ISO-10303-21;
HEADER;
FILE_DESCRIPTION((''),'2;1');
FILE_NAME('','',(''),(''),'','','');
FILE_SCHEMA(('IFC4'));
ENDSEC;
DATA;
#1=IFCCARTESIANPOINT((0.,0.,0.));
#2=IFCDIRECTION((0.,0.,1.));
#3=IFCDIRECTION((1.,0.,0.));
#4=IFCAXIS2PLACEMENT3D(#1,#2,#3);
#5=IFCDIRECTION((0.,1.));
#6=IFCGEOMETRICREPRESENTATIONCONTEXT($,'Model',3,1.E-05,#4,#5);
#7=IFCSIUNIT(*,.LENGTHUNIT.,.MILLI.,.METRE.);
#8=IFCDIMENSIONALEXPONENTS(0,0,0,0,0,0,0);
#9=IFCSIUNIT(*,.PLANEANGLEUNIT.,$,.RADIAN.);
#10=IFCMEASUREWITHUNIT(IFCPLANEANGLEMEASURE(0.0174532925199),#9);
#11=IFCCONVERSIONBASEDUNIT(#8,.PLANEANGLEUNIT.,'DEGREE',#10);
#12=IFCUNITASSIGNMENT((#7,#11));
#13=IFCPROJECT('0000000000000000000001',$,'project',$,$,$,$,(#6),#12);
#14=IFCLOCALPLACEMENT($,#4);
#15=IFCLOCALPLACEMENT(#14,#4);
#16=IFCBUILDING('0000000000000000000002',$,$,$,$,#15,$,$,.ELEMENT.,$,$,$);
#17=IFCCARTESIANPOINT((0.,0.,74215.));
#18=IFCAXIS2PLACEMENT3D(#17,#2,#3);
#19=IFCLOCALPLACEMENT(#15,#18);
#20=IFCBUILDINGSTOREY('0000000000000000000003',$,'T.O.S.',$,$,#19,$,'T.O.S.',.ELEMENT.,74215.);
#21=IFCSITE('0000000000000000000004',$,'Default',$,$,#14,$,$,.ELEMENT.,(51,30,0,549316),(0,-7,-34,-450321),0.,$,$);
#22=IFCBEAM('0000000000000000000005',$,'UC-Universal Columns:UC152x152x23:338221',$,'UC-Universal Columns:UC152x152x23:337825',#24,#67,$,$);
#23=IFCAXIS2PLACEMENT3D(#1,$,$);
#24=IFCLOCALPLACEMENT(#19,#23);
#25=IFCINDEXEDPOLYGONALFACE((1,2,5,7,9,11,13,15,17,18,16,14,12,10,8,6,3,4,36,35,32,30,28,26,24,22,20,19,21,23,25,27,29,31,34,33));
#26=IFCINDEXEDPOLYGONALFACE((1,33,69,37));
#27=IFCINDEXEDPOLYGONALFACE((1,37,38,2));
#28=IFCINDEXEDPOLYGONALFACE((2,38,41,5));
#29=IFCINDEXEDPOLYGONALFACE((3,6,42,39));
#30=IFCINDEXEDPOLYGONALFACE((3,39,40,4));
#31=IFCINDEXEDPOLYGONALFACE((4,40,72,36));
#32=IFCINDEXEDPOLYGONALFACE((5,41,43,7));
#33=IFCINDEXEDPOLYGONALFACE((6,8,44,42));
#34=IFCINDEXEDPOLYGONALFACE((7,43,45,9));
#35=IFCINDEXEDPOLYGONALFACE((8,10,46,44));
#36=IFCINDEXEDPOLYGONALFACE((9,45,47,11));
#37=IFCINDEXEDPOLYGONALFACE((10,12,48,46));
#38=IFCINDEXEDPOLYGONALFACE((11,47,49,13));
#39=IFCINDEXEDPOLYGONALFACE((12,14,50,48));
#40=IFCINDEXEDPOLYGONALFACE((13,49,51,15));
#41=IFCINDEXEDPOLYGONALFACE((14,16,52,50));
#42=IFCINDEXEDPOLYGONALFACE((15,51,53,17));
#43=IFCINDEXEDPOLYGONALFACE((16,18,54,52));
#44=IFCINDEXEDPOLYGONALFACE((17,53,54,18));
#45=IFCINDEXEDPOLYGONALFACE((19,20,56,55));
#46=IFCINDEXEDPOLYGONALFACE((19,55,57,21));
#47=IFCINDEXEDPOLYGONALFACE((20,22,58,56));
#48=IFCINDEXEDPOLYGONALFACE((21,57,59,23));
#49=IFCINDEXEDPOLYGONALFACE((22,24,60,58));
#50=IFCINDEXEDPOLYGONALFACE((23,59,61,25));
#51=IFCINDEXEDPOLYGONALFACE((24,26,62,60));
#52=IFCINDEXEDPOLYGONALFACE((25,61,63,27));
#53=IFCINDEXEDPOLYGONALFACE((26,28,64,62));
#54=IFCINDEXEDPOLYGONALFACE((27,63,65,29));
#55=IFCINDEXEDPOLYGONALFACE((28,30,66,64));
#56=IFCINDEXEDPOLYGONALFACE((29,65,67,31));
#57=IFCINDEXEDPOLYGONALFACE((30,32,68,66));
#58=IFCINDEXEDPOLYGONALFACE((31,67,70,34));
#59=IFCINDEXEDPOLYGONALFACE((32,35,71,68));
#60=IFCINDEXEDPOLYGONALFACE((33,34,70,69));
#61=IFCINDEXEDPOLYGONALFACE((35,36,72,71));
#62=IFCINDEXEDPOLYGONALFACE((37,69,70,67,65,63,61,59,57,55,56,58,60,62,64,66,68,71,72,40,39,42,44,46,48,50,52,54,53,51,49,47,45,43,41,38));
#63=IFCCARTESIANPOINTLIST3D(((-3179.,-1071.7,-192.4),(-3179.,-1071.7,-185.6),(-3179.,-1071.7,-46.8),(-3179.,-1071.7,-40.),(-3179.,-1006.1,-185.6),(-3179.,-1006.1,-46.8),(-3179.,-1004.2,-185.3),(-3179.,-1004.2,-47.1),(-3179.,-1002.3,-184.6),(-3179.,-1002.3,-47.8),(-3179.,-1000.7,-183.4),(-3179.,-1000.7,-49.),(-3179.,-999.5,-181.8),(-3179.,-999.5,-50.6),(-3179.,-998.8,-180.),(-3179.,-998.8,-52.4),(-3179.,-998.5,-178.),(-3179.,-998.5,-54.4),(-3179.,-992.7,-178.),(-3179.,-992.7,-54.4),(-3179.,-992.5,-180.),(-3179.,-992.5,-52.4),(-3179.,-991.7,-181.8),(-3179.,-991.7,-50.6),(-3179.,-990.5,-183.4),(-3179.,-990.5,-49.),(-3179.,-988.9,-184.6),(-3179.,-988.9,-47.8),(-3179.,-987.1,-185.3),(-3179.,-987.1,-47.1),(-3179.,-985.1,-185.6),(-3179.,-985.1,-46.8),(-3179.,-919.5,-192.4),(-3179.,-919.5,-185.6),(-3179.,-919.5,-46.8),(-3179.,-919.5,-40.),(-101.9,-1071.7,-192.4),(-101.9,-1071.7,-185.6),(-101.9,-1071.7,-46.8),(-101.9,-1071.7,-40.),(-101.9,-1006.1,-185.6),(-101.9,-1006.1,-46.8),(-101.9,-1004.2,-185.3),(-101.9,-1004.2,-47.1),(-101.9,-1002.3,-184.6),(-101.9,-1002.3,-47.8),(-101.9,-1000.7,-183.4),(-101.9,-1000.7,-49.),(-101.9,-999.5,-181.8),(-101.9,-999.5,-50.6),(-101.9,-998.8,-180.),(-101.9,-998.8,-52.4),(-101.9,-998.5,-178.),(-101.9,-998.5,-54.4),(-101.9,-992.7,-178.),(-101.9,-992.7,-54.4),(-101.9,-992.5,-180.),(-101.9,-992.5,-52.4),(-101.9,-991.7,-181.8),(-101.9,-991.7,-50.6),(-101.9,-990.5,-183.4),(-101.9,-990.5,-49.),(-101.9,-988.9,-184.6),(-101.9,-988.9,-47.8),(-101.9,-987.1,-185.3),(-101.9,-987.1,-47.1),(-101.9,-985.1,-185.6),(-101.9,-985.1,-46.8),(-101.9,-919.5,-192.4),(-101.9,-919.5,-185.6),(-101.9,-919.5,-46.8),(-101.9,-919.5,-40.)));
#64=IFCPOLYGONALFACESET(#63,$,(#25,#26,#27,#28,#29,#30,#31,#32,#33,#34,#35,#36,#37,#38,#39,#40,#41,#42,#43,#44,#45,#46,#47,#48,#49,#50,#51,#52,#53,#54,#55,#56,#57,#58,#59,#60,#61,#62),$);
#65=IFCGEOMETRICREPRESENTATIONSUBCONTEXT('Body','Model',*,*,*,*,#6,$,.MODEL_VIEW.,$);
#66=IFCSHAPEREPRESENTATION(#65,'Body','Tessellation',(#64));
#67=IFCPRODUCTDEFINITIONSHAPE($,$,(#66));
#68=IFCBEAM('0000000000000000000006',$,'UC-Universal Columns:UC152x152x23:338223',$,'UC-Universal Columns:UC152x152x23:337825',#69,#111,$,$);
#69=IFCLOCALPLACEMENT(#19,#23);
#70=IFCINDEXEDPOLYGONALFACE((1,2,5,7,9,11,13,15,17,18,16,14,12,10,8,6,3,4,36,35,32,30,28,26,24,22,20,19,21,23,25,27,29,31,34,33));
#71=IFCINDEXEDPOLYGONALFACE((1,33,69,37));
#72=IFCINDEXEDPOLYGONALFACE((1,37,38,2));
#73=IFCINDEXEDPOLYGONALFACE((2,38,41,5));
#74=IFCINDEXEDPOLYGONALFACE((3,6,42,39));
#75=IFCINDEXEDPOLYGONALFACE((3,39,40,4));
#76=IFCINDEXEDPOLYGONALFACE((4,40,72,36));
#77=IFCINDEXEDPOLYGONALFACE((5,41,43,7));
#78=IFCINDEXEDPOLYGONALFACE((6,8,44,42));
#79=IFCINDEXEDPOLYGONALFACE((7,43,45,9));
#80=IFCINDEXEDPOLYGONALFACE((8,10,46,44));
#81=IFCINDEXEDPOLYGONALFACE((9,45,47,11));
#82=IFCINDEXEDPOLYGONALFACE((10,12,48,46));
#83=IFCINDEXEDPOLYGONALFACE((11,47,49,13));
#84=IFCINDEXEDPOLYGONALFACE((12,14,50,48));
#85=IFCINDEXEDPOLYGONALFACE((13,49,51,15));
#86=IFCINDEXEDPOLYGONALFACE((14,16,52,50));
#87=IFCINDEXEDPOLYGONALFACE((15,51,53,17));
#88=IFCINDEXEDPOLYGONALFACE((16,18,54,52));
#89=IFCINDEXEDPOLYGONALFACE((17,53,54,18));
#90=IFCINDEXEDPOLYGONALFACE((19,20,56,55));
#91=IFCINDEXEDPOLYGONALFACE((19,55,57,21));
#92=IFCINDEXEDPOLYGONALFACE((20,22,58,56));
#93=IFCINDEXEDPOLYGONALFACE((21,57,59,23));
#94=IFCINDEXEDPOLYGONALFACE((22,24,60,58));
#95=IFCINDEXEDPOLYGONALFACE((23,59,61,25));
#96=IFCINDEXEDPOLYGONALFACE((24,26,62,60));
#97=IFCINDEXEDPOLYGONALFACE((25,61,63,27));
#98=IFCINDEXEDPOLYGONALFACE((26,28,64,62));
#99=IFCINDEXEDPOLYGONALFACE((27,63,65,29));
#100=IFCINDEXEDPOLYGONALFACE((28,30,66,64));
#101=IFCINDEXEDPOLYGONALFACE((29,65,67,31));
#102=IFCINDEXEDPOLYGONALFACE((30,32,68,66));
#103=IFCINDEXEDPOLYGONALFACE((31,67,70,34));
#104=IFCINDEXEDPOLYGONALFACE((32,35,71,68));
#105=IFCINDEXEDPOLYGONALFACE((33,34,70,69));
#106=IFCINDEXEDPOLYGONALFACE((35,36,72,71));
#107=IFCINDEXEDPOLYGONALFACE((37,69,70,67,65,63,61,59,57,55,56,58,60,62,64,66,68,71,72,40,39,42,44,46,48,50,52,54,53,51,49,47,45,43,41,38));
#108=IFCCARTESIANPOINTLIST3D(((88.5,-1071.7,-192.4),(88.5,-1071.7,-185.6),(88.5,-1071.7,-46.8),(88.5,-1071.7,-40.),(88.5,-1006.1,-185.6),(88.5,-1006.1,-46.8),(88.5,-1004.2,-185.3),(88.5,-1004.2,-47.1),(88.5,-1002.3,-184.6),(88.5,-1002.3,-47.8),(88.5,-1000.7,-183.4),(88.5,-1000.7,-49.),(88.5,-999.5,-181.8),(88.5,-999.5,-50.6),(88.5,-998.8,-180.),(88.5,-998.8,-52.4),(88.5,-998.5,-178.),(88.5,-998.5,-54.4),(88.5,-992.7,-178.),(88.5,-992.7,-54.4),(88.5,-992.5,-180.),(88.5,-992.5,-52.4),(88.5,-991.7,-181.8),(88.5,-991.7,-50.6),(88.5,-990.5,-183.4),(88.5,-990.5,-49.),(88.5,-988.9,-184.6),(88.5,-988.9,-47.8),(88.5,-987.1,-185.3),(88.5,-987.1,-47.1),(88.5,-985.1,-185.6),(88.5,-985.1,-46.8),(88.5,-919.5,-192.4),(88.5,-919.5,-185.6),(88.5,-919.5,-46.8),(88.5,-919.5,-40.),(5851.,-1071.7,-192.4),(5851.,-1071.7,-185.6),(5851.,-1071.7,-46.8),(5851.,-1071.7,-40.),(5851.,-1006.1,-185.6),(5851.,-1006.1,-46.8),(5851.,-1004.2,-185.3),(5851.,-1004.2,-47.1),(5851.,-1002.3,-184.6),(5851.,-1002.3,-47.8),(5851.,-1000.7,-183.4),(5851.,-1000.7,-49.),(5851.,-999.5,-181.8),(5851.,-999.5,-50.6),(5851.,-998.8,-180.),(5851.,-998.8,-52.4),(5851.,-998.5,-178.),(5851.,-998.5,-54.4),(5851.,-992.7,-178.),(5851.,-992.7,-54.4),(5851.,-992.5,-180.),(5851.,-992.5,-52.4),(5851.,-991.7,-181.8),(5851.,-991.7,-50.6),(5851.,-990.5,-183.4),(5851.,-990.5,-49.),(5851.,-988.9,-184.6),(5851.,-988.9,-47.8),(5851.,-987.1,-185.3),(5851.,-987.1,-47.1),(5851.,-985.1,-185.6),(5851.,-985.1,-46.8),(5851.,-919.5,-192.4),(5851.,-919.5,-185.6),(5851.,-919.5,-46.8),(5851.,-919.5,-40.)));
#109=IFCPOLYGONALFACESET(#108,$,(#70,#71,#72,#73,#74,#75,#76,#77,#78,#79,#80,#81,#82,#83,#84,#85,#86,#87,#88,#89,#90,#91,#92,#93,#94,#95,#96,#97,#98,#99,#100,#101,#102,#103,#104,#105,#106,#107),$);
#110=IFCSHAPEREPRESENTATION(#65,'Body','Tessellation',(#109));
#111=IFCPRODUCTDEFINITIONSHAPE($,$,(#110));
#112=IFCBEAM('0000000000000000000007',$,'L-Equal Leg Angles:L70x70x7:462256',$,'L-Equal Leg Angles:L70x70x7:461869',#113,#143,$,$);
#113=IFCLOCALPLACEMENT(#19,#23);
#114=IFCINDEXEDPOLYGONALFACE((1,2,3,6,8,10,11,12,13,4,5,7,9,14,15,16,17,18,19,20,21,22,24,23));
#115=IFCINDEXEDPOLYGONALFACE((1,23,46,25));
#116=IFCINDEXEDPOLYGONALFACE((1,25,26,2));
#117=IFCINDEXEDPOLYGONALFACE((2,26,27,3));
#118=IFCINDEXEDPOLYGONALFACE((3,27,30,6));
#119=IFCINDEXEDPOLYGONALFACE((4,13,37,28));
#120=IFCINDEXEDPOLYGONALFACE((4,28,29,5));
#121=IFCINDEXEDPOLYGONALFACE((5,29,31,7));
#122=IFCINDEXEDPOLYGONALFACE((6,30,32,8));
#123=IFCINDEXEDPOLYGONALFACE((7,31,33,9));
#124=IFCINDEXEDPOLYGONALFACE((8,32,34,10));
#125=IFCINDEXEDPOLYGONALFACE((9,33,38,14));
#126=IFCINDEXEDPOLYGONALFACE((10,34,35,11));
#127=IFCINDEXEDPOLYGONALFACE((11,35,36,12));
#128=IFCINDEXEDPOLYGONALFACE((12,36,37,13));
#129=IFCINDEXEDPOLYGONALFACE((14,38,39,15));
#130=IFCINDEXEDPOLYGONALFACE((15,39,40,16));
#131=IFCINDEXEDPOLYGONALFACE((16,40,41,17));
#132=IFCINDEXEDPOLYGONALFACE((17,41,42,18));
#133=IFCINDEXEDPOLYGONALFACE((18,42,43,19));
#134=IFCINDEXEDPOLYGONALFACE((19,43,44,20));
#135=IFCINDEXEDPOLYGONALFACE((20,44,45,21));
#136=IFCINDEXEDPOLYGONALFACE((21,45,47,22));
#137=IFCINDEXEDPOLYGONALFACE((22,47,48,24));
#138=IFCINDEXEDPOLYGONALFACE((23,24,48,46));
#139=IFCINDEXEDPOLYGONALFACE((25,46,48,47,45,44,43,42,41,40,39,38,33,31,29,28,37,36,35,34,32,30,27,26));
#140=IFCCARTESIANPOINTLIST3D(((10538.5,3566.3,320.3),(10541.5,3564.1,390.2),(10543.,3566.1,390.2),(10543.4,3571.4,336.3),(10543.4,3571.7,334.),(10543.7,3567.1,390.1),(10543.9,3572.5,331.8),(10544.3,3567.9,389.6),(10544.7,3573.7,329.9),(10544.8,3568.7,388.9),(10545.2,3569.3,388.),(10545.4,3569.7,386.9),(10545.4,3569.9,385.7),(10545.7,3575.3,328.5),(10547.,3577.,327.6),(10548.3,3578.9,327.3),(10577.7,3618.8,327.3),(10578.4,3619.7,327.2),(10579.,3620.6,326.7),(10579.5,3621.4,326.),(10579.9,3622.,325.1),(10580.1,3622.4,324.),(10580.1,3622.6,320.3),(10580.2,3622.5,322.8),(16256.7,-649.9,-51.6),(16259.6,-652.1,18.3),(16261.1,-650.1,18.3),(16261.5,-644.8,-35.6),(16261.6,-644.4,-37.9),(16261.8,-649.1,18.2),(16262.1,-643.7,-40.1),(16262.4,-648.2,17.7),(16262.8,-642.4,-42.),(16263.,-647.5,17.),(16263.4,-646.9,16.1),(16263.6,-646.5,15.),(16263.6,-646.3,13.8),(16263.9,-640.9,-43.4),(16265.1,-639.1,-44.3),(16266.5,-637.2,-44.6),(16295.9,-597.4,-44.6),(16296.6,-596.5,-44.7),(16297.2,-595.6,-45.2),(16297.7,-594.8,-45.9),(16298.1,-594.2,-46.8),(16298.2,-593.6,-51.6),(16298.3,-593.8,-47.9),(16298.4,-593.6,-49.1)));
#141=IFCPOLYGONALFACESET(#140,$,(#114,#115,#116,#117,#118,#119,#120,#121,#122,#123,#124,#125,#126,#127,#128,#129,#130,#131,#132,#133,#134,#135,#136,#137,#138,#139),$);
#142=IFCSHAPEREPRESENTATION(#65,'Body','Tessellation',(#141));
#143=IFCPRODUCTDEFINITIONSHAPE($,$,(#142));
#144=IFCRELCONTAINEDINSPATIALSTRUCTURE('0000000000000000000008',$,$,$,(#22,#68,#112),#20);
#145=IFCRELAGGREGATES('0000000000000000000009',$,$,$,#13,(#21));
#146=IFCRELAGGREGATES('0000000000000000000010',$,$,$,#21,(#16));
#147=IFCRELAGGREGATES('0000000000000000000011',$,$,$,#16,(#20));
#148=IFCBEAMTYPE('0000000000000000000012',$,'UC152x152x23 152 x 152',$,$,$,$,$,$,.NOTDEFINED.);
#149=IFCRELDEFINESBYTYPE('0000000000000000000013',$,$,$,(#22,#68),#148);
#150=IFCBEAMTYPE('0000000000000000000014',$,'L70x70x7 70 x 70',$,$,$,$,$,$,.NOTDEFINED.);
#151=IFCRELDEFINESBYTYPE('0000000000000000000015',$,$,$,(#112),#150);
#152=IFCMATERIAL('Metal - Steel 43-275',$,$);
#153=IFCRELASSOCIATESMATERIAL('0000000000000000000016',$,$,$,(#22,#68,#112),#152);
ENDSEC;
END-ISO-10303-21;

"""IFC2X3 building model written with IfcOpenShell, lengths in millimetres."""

from ifc_helpers import new_model, entity, si_unit, converted_unit, point, direction, frame, frame_2d, origin_with_axes, place, context, subcontext, project, spatial, polyline, circle_curve, parameter, trimmed, segment, composite_curve, outline, extrude, clip, halfspace, material, type_object, element, save


model = new_model("IFC2X3")

# Units and contexts
model_context = context("Model", 3, precision=1e-05, world=origin_with_axes(), true_north=direction((0.0, 1.0)))
body_context = subcontext(model_context, "Body", "Model", "MODEL_VIEW")
ifc_project = project(units=[si_unit("LENGTHUNIT", "METRE", prefix="MILLI"), converted_unit("PLANEANGLEUNIT", "DEGREE", entity("IfcPlaneAngleMeasure", 0.0174532925199), si_unit("PLANEANGLEUNIT", "RADIAN"), dimensions=[0, 0, 0, 0, 0, 0, 0])], contexts=[model_context])

# Site, building, storey
site_placement = place(None, origin_with_axes())
site = spatial("IfcSite", under=ifc_project, at=site_placement, Name="Default", CompositionType="ELEMENT", RefLatitude=(51, 30, 0, 549316), RefLongitude=(0, -7, -34, -450321), RefElevation=0.0)
building_placement = place(site_placement, origin_with_axes())
building = spatial("IfcBuilding", under=site, at=building_placement, CompositionType="ELEMENT")
storey_placement = place(building_placement, frame((0.0, 0.0, 74215.0), z_axis=(0.0, 0.0, 1.0), x_axis=(1.0, 0.0, 0.0)))
storey = spatial("IfcBuildingStorey", under=building, at=storey_placement, Name="T.O.S.", LongName="T.O.S.", CompositionType="ELEMENT", Elevation=74215.0)

# Beams
ifc_material = material(Name="Metal - Steel 43-275")
beam_type_1 = type_object("IfcBeamType", Name="UC152x152x23 152 x 152", PredefinedType="NOTDEFINED")
beam_1_placement = place(storey_placement, frame((-101.9, -995.6, -116.2), z_axis=(0.0, 0.0, 1.0), x_axis=(0.0, 1.0, 0.0)))
element("IfcBeam", 1, at=beam_1_placement, inside=storey, type_object=beam_type_1, material=ifc_material, Name="UC-Universal Columns:UC152x152x23:338221", ObjectType="UC-Universal Columns:UC152x152x23:337825", context=body_context, shape_type="SweptSolid", body=[
    extrude(outline(composite_curve([segment(polyline([(76.2, 76.1), (69.4, 76.1), (69.4, 10.5)]), True, "CONTINUOUS"), segment(trimmed(circle_curve(frame_2d((61.8, 10.5), x_axis=(0.0, -1.0)), 7.6), [point((69.4, 10.5)), parameter(90.0)], [point((61.8, 2.9)), parameter(0.0)], False, "CARTESIAN"), True, "CONTINUOUS"), segment(polyline([(61.8, 2.9), (-61.8, 2.9)]), True, "CONTINUOUS"), segment(trimmed(circle_curve(frame_2d((-61.8, 10.5), x_axis=(-1.0, 0.0)), 7.6), [point((-61.8, 2.9)), parameter(90.0)], [point((-69.4, 10.5)), parameter(0.0)], False, "CARTESIAN"), True, "CONTINUOUS"), segment(polyline([(-69.4, 10.5), (-69.4, 76.1), (-76.2, 76.1), (-76.2, -76.1), (-69.4, -76.1), (-69.4, -10.5)]), True, "CONTINUOUS"), segment(trimmed(circle_curve(frame_2d((-61.8, -10.5), x_axis=(0.0, 1.0)), 7.6), [point((-69.4, -10.5)), parameter(90.0)], [point((-61.8, -2.9)), parameter(0.0)], False, "CARTESIAN"), True, "CONTINUOUS"), segment(polyline([(-61.8, -2.9), (61.8, -2.9)]), True, "CONTINUOUS"), segment(trimmed(circle_curve(frame_2d((61.8, -10.5), x_axis=(1.0, 0.0)), 7.6), [point((61.8, -2.9)), parameter(90.0)], [point((69.4, -10.5)), parameter(0.0)], False, "CARTESIAN"), True, "CONTINUOUS"), segment(polyline([(69.4, -10.5), (69.4, -76.1), (76.2, -76.1), (76.2, 76.1)]), True, "CONTINUOUS")], self_intersect=False)), frame((0.0, 3077.1, 0.0), z_axis=(0.0, -1.0, 0.0), x_axis=(0.0, 0.0, -1.0)), (0.0, 0.0, 1.0), 3077.1),
])
beam_2_placement = place(storey_placement, frame((5851.0, -995.6, -116.2), z_axis=(0.0, 0.0, 1.0), x_axis=(0.0, 1.0, 0.0)))
element("IfcBeam", 2, at=beam_2_placement, inside=storey, type_object=beam_type_1, material=ifc_material, Name="UC-Universal Columns:UC152x152x23:338223", ObjectType="UC-Universal Columns:UC152x152x23:337825", context=body_context, shape_type="SweptSolid", body=[
    extrude(outline(composite_curve([segment(polyline([(76.2, 76.1), (69.4, 76.1), (69.4, 10.5)]), True, "CONTINUOUS"), segment(trimmed(circle_curve(frame_2d((61.8, 10.5), x_axis=(0.0, -1.0)), 7.6), [point((69.4, 10.5)), parameter(90.0)], [point((61.8, 2.9)), parameter(0.0)], False, "CARTESIAN"), True, "CONTINUOUS"), segment(polyline([(61.8, 2.9), (-61.8, 2.9)]), True, "CONTINUOUS"), segment(trimmed(circle_curve(frame_2d((-61.8, 10.5), x_axis=(-1.0, 0.0)), 7.6), [point((-61.8, 2.9)), parameter(90.0)], [point((-69.4, 10.5)), parameter(0.0)], False, "CARTESIAN"), True, "CONTINUOUS"), segment(polyline([(-69.4, 10.5), (-69.4, 76.1), (-76.2, 76.1), (-76.2, -76.1), (-69.4, -76.1), (-69.4, -10.5)]), True, "CONTINUOUS"), segment(trimmed(circle_curve(frame_2d((-61.8, -10.5), x_axis=(0.0, 1.0)), 7.6), [point((-69.4, -10.5)), parameter(90.0)], [point((-61.8, -2.9)), parameter(0.0)], False, "CARTESIAN"), True, "CONTINUOUS"), segment(polyline([(-61.8, -2.9), (61.8, -2.9)]), True, "CONTINUOUS"), segment(trimmed(circle_curve(frame_2d((61.8, -10.5), x_axis=(1.0, 0.0)), 7.6), [point((61.8, -2.9)), parameter(90.0)], [point((69.4, -10.5)), parameter(0.0)], False, "CARTESIAN"), True, "CONTINUOUS"), segment(polyline([(69.4, -10.5), (69.4, -76.1), (76.2, -76.1), (76.2, 76.1)]), True, "CONTINUOUS")], self_intersect=False)), frame((0.0, 5762.5, 0.0), z_axis=(0.0, -1.0, 0.0), x_axis=(0.0, 0.0, -1.0)), (0.0, 0.0, 1.0), 5762.5),
])
beam_type_2 = type_object("IfcBeamType", Name="L70x70x7 70 x 70", PredefinedType="NOTDEFINED")
beam_3_placement = place(storey_placement, frame((10551.2, 3589.8, 347.0), z_axis=(0.0, 0.0, 1.0), x_axis=(-0.593453, -0.804869, 0.0)))
element("IfcBeam", 3, at=beam_3_placement, inside=storey, type_object=beam_type_2, material=ifc_material, Name="L-Equal Leg Angles:L70x70x7:462256", ObjectType="L-Equal Leg Angles:L70x70x7:461869", context=body_context, shape_type="Clipping", body=[
    clip(clip(clip(clip(extrude(outline(composite_curve([segment(polyline([(23.9, -43.6), (26.4, -43.6), (26.4, 26.4), (-43.6, 26.4), (-43.6, 23.9)]), True, "CONTINUOUS"), segment(trimmed(circle_curve(frame_2d((-39.1, 23.9), x_axis=(-1.0, 0.0)), 4.5), [point((-43.6, 23.9)), parameter(0.0)], [point((-39.1, 19.4)), parameter(90.0)], True, "CARTESIAN"), True, "CONTINUOUS"), segment(polyline([(-39.1, 19.4), (10.4, 19.4)]), True, "CONTINUOUS"), segment(trimmed(circle_curve(frame_2d((10.4, 10.4), x_axis=(1.0, 0.0)), 9.0), [point((10.4, 19.4)), parameter(90.0)], [point((19.4, 10.4)), parameter(0.0)], False, "CARTESIAN"), True, "CONTINUOUS"), segment(polyline([(19.4, 10.4), (19.4, -39.1)]), True, "CONTINUOUS"), segment(trimmed(circle_curve(frame_2d((23.9, -39.1), x_axis=(-1.0, 0.0)), 4.5), [point((19.4, -39.1)), parameter(0.0)], [point((23.9, -43.6)), parameter(90.0)], True, "CARTESIAN"), True, "CONTINUOUS")], self_intersect=False)), frame((0.0, 7120.0, -372.7), z_axis=(0.0, -0.998633, 0.052275), x_axis=(0.0, -0.052275, -0.998633)), (0.0, 0.0, 1.0), 7134.9), halfspace(frame((0.0, 7109.6, -372.2), z_axis=(0.0, -0.998633, 0.052275), x_axis=(0.0, -0.052275, -0.998633)), True)), halfspace(frame((0.0, 5.2, -0.3), z_axis=(0.0, 0.998633, -0.052275), x_axis=(0.0, 0.052275, 0.998633)), True)), halfspace(frame((0.0, 7114.8, 0.0), z_axis=(0.0, -1.0, 0.0), x_axis=(0.0, 0.0, -1.0)), True)), halfspace(frame((0.0, 0.0, 0.0), z_axis=(0.0, 1.0, 0.0), x_axis=(0.0, 0.0, 1.0)), True)),
])

save(model, "model.ifc")
